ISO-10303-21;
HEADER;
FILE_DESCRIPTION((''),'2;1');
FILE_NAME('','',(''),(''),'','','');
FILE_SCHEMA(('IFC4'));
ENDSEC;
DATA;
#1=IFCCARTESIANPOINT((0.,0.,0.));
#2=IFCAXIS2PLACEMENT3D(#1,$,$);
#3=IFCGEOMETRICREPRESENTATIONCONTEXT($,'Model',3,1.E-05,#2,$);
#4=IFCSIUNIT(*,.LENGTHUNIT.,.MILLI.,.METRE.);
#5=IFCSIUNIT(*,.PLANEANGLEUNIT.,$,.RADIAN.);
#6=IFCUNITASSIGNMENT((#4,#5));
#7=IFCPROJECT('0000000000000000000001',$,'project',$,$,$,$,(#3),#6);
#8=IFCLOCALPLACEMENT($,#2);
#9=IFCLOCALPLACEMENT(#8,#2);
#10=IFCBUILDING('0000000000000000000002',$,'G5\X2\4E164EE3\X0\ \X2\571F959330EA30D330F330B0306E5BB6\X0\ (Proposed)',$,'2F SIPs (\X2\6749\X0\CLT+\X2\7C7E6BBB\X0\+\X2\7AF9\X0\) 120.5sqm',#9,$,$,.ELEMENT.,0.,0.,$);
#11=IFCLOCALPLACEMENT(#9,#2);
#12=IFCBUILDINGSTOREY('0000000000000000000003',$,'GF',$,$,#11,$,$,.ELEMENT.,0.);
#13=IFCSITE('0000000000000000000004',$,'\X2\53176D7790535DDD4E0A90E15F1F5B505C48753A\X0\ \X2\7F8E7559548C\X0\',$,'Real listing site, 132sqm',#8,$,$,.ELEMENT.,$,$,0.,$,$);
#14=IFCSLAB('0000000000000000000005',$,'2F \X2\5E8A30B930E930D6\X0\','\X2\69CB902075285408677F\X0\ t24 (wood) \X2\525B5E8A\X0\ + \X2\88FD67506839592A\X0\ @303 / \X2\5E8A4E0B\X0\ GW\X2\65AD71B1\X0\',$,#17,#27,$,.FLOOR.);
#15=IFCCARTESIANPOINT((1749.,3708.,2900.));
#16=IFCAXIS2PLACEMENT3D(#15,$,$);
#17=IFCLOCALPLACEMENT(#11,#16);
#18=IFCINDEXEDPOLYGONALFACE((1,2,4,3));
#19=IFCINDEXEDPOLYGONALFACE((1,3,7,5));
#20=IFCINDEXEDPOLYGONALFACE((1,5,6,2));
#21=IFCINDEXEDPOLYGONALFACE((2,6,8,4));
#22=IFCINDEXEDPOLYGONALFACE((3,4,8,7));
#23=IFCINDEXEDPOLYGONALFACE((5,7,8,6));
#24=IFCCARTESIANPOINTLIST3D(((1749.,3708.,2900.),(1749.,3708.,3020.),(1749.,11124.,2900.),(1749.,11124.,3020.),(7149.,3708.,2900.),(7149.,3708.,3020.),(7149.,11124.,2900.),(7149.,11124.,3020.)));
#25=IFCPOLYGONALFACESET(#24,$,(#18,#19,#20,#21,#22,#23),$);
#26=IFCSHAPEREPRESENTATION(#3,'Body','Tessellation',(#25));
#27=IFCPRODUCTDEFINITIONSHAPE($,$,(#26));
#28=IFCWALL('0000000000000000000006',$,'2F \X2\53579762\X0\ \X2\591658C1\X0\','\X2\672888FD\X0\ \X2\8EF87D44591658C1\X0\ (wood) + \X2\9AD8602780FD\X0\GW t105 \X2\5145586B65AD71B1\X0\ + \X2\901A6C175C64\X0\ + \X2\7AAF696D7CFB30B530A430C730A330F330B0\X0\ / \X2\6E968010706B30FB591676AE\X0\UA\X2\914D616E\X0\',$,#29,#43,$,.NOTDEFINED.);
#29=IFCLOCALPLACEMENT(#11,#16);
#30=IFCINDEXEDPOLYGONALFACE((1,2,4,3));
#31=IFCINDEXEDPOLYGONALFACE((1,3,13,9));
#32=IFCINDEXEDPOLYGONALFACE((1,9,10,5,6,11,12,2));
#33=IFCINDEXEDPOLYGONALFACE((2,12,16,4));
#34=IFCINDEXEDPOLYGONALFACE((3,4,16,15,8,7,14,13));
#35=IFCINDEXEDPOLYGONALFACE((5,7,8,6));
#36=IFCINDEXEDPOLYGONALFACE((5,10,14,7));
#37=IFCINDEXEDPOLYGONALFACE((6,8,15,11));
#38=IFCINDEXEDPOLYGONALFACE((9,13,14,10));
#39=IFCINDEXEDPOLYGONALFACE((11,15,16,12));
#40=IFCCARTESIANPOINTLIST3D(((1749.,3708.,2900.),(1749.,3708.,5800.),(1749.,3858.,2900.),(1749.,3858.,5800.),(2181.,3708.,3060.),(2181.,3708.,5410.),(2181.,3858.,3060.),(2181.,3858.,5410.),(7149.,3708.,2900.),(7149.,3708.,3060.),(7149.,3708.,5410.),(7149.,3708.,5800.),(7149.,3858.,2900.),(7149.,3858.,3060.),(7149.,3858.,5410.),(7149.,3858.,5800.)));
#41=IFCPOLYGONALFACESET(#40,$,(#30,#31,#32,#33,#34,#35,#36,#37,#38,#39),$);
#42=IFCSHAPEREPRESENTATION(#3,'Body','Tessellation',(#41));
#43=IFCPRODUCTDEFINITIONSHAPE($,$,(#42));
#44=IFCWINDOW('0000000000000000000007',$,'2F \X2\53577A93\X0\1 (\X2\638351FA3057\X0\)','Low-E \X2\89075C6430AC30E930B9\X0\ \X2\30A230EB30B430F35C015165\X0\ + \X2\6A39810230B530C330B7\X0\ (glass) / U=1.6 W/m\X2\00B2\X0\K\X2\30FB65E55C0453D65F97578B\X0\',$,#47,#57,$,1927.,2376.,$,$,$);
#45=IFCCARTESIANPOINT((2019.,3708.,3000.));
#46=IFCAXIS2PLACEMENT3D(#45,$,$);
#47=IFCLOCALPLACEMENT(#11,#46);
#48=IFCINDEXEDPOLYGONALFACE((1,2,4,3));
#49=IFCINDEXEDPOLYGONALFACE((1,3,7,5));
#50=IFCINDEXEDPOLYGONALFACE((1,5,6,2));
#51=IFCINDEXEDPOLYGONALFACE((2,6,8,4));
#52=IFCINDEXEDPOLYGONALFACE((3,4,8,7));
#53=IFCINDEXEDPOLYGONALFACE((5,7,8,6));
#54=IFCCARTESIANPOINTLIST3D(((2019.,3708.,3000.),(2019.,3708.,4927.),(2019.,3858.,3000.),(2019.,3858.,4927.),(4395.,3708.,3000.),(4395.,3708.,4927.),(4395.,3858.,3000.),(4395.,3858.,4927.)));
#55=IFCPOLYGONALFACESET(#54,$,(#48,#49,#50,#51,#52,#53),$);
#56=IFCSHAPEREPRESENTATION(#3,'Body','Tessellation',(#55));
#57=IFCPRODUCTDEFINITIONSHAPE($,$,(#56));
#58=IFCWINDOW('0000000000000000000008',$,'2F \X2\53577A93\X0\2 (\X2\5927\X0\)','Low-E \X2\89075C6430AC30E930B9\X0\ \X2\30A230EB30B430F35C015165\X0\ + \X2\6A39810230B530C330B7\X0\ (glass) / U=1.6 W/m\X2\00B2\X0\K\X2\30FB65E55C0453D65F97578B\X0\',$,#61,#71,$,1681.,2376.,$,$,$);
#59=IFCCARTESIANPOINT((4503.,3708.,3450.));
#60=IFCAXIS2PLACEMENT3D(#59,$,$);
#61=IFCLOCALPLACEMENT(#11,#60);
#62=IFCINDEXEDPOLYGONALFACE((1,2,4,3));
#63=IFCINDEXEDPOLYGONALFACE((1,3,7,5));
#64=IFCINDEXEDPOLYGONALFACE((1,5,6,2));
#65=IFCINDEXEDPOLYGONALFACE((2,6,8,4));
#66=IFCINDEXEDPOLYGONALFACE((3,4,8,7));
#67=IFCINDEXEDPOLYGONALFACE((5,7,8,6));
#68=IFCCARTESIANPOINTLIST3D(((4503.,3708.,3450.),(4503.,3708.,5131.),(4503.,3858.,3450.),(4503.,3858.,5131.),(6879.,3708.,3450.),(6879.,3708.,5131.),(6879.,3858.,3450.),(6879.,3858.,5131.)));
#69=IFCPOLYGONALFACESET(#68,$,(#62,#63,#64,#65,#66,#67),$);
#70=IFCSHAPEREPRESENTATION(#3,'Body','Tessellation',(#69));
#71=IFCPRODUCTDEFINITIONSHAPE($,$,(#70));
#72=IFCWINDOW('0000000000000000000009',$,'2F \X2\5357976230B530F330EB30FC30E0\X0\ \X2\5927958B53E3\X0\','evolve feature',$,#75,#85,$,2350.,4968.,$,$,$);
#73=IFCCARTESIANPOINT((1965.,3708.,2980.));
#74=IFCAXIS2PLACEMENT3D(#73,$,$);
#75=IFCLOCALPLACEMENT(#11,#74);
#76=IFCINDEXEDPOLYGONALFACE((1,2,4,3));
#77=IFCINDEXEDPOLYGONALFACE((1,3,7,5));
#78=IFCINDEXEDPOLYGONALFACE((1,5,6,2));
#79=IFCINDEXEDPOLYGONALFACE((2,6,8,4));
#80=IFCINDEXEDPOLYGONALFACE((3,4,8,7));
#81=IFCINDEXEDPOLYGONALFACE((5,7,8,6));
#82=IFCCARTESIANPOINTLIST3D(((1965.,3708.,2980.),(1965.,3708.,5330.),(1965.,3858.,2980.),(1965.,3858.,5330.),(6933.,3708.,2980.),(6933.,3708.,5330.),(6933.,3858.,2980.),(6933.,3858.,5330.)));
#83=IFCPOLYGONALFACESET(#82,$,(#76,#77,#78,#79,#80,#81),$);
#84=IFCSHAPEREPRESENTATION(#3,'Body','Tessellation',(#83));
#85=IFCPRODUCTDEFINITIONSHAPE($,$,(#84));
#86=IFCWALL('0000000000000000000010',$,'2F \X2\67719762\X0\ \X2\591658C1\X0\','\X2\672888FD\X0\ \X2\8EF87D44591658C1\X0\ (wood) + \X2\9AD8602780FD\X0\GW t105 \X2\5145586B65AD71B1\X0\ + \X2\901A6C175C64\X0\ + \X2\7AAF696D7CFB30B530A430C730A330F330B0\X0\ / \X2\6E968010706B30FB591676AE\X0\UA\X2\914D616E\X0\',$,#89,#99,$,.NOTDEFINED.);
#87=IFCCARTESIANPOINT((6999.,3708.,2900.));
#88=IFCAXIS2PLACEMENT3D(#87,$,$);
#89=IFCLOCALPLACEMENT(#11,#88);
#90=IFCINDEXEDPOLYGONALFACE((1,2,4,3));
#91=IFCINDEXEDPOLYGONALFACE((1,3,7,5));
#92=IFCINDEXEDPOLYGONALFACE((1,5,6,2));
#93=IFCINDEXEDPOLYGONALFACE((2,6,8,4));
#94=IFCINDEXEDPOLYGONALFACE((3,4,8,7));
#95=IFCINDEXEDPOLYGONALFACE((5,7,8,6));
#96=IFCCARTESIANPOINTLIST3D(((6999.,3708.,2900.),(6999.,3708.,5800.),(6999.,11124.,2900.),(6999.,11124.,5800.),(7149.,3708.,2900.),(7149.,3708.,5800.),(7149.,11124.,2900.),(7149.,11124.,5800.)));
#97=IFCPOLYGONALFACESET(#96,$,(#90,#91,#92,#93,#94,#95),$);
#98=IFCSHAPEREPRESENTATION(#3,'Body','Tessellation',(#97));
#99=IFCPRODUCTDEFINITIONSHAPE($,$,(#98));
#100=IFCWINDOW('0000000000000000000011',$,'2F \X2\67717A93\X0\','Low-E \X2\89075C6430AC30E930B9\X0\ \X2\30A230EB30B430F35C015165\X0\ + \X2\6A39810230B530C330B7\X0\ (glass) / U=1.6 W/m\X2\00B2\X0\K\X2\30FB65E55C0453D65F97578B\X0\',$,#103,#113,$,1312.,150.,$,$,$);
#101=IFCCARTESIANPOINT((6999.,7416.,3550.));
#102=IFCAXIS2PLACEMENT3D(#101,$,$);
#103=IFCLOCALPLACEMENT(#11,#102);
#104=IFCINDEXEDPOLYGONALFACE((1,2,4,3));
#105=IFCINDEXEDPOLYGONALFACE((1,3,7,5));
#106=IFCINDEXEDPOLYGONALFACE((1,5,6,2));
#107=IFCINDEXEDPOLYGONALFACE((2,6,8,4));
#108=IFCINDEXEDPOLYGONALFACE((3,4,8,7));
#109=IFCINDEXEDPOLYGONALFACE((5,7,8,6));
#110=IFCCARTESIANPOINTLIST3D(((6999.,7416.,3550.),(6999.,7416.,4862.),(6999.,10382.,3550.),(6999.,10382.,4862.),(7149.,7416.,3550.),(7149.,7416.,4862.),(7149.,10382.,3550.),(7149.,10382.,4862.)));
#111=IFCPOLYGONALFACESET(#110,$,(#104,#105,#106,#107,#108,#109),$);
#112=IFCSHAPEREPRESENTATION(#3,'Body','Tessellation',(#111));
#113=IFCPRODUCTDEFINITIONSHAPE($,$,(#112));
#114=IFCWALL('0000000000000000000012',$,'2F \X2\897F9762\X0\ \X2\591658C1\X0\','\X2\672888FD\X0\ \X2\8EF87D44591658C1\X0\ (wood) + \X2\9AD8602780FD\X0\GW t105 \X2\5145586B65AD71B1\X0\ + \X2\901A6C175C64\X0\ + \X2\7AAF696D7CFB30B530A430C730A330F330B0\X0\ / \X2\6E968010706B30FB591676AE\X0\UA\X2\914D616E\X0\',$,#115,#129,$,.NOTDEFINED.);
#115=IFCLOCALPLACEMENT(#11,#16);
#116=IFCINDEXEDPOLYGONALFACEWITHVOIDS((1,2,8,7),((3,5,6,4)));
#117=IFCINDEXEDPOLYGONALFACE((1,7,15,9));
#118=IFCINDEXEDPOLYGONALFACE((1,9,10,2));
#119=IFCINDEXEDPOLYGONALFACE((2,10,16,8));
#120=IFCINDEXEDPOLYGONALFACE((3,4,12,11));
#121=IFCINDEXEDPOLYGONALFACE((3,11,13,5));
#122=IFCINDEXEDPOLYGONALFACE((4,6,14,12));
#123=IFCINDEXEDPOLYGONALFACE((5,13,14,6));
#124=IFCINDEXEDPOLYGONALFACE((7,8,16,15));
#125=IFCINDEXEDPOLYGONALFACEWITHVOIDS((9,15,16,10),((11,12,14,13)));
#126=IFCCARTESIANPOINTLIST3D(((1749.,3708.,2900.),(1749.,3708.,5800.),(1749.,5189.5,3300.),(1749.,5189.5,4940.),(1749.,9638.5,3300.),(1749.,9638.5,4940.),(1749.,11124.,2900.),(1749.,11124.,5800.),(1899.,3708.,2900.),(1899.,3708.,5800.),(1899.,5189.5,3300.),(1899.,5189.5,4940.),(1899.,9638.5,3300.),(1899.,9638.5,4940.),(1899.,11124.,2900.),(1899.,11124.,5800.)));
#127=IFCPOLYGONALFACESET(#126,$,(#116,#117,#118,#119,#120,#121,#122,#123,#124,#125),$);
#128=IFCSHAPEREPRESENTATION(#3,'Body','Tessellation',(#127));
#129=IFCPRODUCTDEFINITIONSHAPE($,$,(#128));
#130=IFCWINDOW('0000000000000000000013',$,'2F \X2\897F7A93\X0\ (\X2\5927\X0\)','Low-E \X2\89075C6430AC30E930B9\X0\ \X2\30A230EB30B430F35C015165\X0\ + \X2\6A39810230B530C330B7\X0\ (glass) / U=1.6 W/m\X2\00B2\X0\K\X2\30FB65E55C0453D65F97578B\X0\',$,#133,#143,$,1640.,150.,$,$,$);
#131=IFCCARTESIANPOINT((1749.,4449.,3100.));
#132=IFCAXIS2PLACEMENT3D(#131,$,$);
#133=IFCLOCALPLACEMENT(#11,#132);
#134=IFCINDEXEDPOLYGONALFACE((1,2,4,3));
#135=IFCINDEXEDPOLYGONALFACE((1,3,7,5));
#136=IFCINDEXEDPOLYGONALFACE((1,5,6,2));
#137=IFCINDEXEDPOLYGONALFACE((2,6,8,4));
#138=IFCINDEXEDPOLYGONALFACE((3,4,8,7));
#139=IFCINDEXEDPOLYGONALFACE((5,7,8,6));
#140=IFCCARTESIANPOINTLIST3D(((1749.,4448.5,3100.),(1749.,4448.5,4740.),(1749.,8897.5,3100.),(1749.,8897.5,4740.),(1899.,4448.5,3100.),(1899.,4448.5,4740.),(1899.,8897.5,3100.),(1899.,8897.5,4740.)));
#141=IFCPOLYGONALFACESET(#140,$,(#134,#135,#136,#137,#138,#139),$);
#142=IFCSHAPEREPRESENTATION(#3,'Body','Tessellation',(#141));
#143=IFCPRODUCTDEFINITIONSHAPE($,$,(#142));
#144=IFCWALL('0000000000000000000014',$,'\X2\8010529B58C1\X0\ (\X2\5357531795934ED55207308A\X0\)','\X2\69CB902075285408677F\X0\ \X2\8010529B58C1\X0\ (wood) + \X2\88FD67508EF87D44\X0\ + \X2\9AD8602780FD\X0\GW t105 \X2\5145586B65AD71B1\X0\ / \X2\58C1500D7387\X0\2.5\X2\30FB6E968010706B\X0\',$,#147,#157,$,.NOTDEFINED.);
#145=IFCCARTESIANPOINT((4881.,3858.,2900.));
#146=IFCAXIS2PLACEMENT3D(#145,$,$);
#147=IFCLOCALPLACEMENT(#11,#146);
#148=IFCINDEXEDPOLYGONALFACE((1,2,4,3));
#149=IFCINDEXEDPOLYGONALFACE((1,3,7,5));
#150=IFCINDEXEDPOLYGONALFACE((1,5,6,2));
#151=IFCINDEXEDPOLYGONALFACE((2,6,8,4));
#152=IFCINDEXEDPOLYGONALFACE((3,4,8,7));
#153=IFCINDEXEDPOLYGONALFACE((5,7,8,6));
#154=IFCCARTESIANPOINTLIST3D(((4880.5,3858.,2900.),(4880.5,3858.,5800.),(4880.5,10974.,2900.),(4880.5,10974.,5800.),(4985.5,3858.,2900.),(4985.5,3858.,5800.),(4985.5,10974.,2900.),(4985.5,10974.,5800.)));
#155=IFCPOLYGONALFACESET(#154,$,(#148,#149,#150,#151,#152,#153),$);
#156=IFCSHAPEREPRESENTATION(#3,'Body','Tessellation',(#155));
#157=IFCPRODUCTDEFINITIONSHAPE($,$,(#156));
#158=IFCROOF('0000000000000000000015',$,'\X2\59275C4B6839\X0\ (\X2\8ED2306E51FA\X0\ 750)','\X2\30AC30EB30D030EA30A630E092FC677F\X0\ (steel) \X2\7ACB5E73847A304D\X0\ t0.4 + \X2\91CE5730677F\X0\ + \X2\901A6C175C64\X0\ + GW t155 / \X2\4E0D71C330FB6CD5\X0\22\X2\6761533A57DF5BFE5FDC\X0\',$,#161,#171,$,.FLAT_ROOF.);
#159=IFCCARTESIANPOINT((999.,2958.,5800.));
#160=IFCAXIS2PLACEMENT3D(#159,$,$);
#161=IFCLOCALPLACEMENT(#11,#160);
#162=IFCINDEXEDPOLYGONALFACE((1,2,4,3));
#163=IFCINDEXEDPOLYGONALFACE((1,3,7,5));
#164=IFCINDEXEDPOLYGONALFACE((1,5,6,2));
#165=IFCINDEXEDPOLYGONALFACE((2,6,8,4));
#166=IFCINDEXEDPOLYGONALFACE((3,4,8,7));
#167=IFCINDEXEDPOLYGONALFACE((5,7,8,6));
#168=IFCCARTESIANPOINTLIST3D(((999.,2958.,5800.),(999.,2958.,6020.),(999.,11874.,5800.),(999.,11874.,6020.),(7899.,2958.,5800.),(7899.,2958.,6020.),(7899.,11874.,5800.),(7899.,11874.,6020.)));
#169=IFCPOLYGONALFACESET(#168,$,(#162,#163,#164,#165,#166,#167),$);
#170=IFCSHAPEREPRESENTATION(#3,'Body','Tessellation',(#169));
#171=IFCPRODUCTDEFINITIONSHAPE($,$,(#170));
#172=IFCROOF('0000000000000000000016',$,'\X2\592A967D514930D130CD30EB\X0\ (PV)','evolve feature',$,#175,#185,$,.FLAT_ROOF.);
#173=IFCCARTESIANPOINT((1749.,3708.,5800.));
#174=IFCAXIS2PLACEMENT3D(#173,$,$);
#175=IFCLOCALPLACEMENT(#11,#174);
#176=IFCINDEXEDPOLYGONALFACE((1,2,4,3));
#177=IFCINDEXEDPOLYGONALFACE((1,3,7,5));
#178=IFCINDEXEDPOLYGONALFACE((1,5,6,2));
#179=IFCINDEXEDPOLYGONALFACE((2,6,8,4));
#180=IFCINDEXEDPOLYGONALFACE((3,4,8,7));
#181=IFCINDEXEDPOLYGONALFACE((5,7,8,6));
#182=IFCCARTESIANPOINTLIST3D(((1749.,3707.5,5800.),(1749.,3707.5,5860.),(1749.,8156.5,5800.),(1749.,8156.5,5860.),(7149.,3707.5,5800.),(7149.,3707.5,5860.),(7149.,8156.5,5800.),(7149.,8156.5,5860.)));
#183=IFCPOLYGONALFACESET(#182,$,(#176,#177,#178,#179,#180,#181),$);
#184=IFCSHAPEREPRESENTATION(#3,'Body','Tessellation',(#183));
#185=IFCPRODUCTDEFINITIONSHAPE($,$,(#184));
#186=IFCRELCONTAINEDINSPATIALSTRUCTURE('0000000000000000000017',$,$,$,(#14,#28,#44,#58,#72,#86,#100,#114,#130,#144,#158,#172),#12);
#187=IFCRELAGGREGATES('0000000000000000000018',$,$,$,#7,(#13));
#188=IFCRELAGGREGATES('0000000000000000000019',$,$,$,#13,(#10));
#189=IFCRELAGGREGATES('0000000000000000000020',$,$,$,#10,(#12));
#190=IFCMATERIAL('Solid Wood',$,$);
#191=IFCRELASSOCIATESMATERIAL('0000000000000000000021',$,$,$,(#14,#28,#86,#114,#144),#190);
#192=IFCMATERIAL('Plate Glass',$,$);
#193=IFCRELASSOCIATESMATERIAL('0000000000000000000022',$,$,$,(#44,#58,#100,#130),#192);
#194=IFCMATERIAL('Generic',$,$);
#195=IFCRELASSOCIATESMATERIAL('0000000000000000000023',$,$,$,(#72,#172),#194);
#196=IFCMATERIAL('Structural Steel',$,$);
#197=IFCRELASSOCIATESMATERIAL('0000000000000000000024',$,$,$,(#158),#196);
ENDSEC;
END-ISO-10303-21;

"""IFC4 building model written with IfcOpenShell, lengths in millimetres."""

from ifc_helpers import new_model, si_unit, frame, frame_2d, origin, place, context, project, spatial, rectangle, extrude, material, element, fill, save


model = new_model("IFC4")

# Units and contexts
model_context = context("Model", 3, precision=1e-05, world=origin())
ifc_project = project(units=[si_unit("LENGTHUNIT", "METRE", prefix="MILLI"), si_unit("PLANEANGLEUNIT", "RADIAN")], contexts=[model_context])

# Site, building, storey
site_placement = place(None, origin())
site = spatial("IfcSite", under=ifc_project, at=site_placement, Name="北海道川上郡弟子屈町 美留和", ObjectType="Real listing site, 132sqm", CompositionType="ELEMENT", RefElevation=0.0)
building_placement = place(site_placement, origin())
building = spatial("IfcBuilding", under=site, at=building_placement, Name="G5世代 土間リビングの家 (Proposed)", ObjectType="2F SIPs (杉CLT+籾殻+竹) 120.5sqm", CompositionType="ELEMENT", ElevationOfRefHeight=0.0, ElevationOfTerrain=0.0)
storey_placement = place(building_placement, origin())
storey = spatial("IfcBuildingStorey", under=building, at=storey_placement, Name="GF", CompositionType="ELEMENT", Elevation=0.0)

# Slab
ifc_material_1 = material(Name="Solid Wood")
slab_placement = place(storey_placement, frame((1749.0, 3708.0, 2900.0)))
element("IfcSlab", 1, at=slab_placement, inside=storey, material=ifc_material_1, Name="2F 床スラブ", Description="構造用合板 t24 (wood) 剛床 + 製材根太 @303 / 床下 GW断熱", PredefinedType="FLOOR", context=model_context, shape_type="SweptSolid", body=[
    extrude(rectangle(XDim=5400.0, YDim=7416.0, at=frame_2d((2700.0, 3708.0))), frame((1749.0, 3708.0, 2900.0)), (0.0, 0.0, 1.0), 120.0),
])

# Wall, openings, windows
wall_1_placement = place(storey_placement, frame((1749.0, 3708.0, 2900.0)))
wall_1 = element("IfcWall", 2, at=wall_1_placement, inside=storey, material=ifc_material_1, Name="2F 南面 外壁", Description="木製 軸組外壁 (wood) + 高性能GW t105 充填断熱 + 通気層 + 窯業系サイディング / 準耐火・外皮UA配慮", PredefinedType="NOTDEFINED", context=model_context, shape_type="SweptSolid", body=[
    extrude(rectangle(XDim=5400.0, YDim=150.0, at=frame_2d((2700.0, 75.0))), frame((1749.0, 3708.0, 2900.0)), (0.0, 0.0, 1.0), 2900.0),
])
opening_1_placement = place(storey_placement, frame((2019.0, 3708.0, 3000.0)))
opening_1 = element("IfcOpeningElement", 3, at=opening_1_placement, cuts=wall_1, PredefinedType="NOTDEFINED", context=model_context, shape_type="SweptSolid", body=[
    extrude(rectangle(XDim=2376.0, YDim=150.0, at=frame_2d((1188.0, 75.0))), frame((2019.0, 3708.0, 3000.0)), (0.0, 0.0, 1.0), 1927.0),
])
opening_2_placement = place(storey_placement, frame((4503.0, 3708.0, 3450.0)))
opening_2 = element("IfcOpeningElement", 4, at=opening_2_placement, cuts=wall_1, PredefinedType="NOTDEFINED", context=model_context, shape_type="SweptSolid", body=[
    extrude(rectangle(XDim=2376.0, YDim=150.0, at=frame_2d((1188.0, 75.0))), frame((4503.0, 3708.0, 3450.0)), (0.0, 0.0, 1.0), 1681.0),
])
opening_3_placement = place(storey_placement, frame((1965.0, 3708.0, 2980.0)))
opening_3 = element("IfcOpeningElement", 5, at=opening_3_placement, cuts=wall_1, PredefinedType="NOTDEFINED", context=model_context, shape_type="SweptSolid", body=[
    extrude(rectangle(XDim=4968.0, YDim=150.0, at=frame_2d((2484.0, 75.0))), frame((1965.0, 3708.0, 2980.0)), (0.0, 0.0, 1.0), 2350.0),
])
ifc_material_2 = material(Name="Plate Glass")
window_1_placement = place(storey_placement, frame((2019.0, 3708.0, 3000.0)))
window_1 = element("IfcWindow", 6, at=window_1_placement, inside=storey, material=ifc_material_2, Name="2F 南窓1 (掃出し)", Description="Low-E 複層ガラス アルゴン封入 + 樹脂サッシ (glass) / U=1.6 W/m²K・日射取得型", OverallHeight=1927.0, OverallWidth=2376.0, context=model_context, shape_type="SweptSolid", body=[
    extrude(rectangle(XDim=2376.0, YDim=150.0, at=frame_2d((1188.0, 75.0))), frame((2019.0, 3708.0, 3000.0)), (0.0, 0.0, 1.0), 1927.0),
])
fill(opening_1, window_1)
window_2_placement = place(storey_placement, frame((4503.0, 3708.0, 3450.0)))
window_2 = element("IfcWindow", 7, at=window_2_placement, inside=storey, material=ifc_material_2, Name="2F 南窓2 (大)", Description="Low-E 複層ガラス アルゴン封入 + 樹脂サッシ (glass) / U=1.6 W/m²K・日射取得型", OverallHeight=1681.0, OverallWidth=2376.0, context=model_context, shape_type="SweptSolid", body=[
    extrude(rectangle(XDim=2376.0, YDim=150.0, at=frame_2d((1188.0, 75.0))), frame((4503.0, 3708.0, 3450.0)), (0.0, 0.0, 1.0), 1681.0),
])
fill(opening_2, window_2)
ifc_material_3 = material(Name="Generic")
window_3_placement = place(storey_placement, frame((1965.0, 3708.0, 2980.0)))
window_3 = element("IfcWindow", 8, at=window_3_placement, inside=storey, material=ifc_material_3, Name="2F 南面サンルーム 大開口", Description="evolve feature", OverallHeight=2350.0, OverallWidth=4968.0, context=model_context, shape_type="SweptSolid", body=[
    extrude(rectangle(XDim=4968.0, YDim=150.0, at=frame_2d((2484.0, 75.0))), frame((1965.0, 3708.0, 2980.0)), (0.0, 0.0, 1.0), 2350.0),
])
fill(opening_3, window_3)

# Walls, openings, windows
wall_2_placement = place(storey_placement, frame((6999.0, 3708.0, 2900.0)))
wall_2 = element("IfcWall", 9, at=wall_2_placement, inside=storey, material=ifc_material_1, Name="2F 東面 外壁", Description="木製 軸組外壁 (wood) + 高性能GW t105 充填断熱 + 通気層 + 窯業系サイディング / 準耐火・外皮UA配慮", PredefinedType="NOTDEFINED", context=model_context, shape_type="SweptSolid", body=[
    extrude(rectangle(XDim=150.0, YDim=7416.0, at=frame_2d((75.0, 3708.0))), frame((6999.0, 3708.0, 2900.0)), (0.0, 0.0, 1.0), 2900.0),
])
opening_4_placement = place(storey_placement, frame((6999.0, 7416.0, 3550.0)))
opening_4 = element("IfcOpeningElement", 10, at=opening_4_placement, cuts=wall_2, PredefinedType="NOTDEFINED", context=model_context, shape_type="SweptSolid", body=[
    extrude(rectangle(XDim=150.0, YDim=2966.0, at=frame_2d((75.0, 1483.0))), frame((6999.0, 7416.0, 3550.0)), (0.0, 0.0, 1.0), 1312.0),
])
window_4_placement = place(storey_placement, frame((6999.0, 7416.0, 3550.0)))
window_4 = element("IfcWindow", 11, at=window_4_placement, inside=storey, material=ifc_material_2, Name="2F 東窓", Description="Low-E 複層ガラス アルゴン封入 + 樹脂サッシ (glass) / U=1.6 W/m²K・日射取得型", OverallHeight=1312.0, OverallWidth=150.0, context=model_context, shape_type="SweptSolid", body=[
    extrude(rectangle(XDim=150.0, YDim=2966.0, at=frame_2d((75.0, 1483.0))), frame((6999.0, 7416.0, 3550.0)), (0.0, 0.0, 1.0), 1312.0),
])
fill(opening_4, window_4)
wall_3_placement = place(storey_placement, frame((1749.0, 3708.0, 2900.0)))
wall_3 = element("IfcWall", 12, at=wall_3_placement, inside=storey, material=ifc_material_1, Name="2F 西面 外壁", Description="木製 軸組外壁 (wood) + 高性能GW t105 充填断熱 + 通気層 + 窯業系サイディング / 準耐火・外皮UA配慮", PredefinedType="NOTDEFINED", context=model_context, shape_type="SweptSolid", body=[
    extrude(rectangle(XDim=150.0, YDim=7416.0, at=frame_2d((75.0, 3708.0))), frame((1749.0, 3708.0, 2900.0)), (0.0, 0.0, 1.0), 2900.0),
])
opening_5_placement = place(storey_placement, frame((1749.0, 4449.0, 3100.0)))
opening_5 = element("IfcOpeningElement", 13, at=opening_5_placement, cuts=wall_3, PredefinedType="NOTDEFINED", context=model_context, shape_type="SweptSolid", body=[
    extrude(rectangle(XDim=150.0, YDim=4449.0, at=frame_2d((75.0, 2224.0))), frame((1749.0, 4449.0, 3100.0)), (0.0, 0.0, 1.0), 1640.0),
])
window_5_placement = place(storey_placement, frame((1749.0, 4449.0, 3100.0)))
window_5 = element("IfcWindow", 14, at=window_5_placement, inside=storey, material=ifc_material_2, Name="2F 西窓 (大)", Description="Low-E 複層ガラス アルゴン封入 + 樹脂サッシ (glass) / U=1.6 W/m²K・日射取得型", OverallHeight=1640.0, OverallWidth=150.0, context=model_context, shape_type="SweptSolid", body=[
    extrude(rectangle(XDim=150.0, YDim=4449.0, at=frame_2d((75.0, 2224.0))), frame((1749.0, 4449.0, 3100.0)), (0.0, 0.0, 1.0), 1640.0),
])
fill(opening_5, window_5)

# Wall
wall_4_placement = place(storey_placement, frame((4881.0, 3858.0, 2900.0)))
element("IfcWall", 15, at=wall_4_placement, inside=storey, material=ifc_material_1, Name="耐力壁 (南北間仕切り)", Description="構造用合板 耐力壁 (wood) + 製材軸組 + 高性能GW t105 充填断熱 / 壁倍率2.5・準耐火", PredefinedType="NOTDEFINED", context=model_context, shape_type="SweptSolid", body=[
    extrude(rectangle(XDim=105.0, YDim=7116.0, at=frame_2d((52.0, 3558.0))), frame((4881.0, 3858.0, 2900.0)), (0.0, 0.0, 1.0), 2900.0),
])

# Roofs
ifc_material_4 = material(Name="Structural Steel")
roof_1_placement = place(storey_placement, frame((999.0, 2958.0, 5800.0)))
element("IfcRoof", 16, at=roof_1_placement, inside=storey, material=ifc_material_4, Name="大屋根 (軒の出 750)", Description="ガルバリウム鋼板 (steel) 立平葺き t0.4 + 野地板 + 通気層 + GW t155 / 不燃・法22条区域対応", PredefinedType="FLAT_ROOF", context=model_context, shape_type="SweptSolid", body=[
    extrude(rectangle(XDim=6900.0, YDim=8916.0, at=frame_2d((3450.0, 4458.0))), frame((999.0, 2958.0, 5800.0)), (0.0, 0.0, 1.0), 220.0),
])
roof_2_placement = place(storey_placement, frame((1749.0, 3708.0, 5800.0)))
element("IfcRoof", 17, at=roof_2_placement, inside=storey, material=ifc_material_3, Name="太陽光パネル (PV)", Description="evolve feature", PredefinedType="FLAT_ROOF", context=model_context, shape_type="SweptSolid", body=[
    extrude(rectangle(XDim=5400.0, YDim=4449.0, at=frame_2d((2700.0, 2224.0))), frame((1749.0, 3708.0, 5800.0)), (0.0, 0.0, 1.0), 60.0),
])

save(model, "model.ifc")
